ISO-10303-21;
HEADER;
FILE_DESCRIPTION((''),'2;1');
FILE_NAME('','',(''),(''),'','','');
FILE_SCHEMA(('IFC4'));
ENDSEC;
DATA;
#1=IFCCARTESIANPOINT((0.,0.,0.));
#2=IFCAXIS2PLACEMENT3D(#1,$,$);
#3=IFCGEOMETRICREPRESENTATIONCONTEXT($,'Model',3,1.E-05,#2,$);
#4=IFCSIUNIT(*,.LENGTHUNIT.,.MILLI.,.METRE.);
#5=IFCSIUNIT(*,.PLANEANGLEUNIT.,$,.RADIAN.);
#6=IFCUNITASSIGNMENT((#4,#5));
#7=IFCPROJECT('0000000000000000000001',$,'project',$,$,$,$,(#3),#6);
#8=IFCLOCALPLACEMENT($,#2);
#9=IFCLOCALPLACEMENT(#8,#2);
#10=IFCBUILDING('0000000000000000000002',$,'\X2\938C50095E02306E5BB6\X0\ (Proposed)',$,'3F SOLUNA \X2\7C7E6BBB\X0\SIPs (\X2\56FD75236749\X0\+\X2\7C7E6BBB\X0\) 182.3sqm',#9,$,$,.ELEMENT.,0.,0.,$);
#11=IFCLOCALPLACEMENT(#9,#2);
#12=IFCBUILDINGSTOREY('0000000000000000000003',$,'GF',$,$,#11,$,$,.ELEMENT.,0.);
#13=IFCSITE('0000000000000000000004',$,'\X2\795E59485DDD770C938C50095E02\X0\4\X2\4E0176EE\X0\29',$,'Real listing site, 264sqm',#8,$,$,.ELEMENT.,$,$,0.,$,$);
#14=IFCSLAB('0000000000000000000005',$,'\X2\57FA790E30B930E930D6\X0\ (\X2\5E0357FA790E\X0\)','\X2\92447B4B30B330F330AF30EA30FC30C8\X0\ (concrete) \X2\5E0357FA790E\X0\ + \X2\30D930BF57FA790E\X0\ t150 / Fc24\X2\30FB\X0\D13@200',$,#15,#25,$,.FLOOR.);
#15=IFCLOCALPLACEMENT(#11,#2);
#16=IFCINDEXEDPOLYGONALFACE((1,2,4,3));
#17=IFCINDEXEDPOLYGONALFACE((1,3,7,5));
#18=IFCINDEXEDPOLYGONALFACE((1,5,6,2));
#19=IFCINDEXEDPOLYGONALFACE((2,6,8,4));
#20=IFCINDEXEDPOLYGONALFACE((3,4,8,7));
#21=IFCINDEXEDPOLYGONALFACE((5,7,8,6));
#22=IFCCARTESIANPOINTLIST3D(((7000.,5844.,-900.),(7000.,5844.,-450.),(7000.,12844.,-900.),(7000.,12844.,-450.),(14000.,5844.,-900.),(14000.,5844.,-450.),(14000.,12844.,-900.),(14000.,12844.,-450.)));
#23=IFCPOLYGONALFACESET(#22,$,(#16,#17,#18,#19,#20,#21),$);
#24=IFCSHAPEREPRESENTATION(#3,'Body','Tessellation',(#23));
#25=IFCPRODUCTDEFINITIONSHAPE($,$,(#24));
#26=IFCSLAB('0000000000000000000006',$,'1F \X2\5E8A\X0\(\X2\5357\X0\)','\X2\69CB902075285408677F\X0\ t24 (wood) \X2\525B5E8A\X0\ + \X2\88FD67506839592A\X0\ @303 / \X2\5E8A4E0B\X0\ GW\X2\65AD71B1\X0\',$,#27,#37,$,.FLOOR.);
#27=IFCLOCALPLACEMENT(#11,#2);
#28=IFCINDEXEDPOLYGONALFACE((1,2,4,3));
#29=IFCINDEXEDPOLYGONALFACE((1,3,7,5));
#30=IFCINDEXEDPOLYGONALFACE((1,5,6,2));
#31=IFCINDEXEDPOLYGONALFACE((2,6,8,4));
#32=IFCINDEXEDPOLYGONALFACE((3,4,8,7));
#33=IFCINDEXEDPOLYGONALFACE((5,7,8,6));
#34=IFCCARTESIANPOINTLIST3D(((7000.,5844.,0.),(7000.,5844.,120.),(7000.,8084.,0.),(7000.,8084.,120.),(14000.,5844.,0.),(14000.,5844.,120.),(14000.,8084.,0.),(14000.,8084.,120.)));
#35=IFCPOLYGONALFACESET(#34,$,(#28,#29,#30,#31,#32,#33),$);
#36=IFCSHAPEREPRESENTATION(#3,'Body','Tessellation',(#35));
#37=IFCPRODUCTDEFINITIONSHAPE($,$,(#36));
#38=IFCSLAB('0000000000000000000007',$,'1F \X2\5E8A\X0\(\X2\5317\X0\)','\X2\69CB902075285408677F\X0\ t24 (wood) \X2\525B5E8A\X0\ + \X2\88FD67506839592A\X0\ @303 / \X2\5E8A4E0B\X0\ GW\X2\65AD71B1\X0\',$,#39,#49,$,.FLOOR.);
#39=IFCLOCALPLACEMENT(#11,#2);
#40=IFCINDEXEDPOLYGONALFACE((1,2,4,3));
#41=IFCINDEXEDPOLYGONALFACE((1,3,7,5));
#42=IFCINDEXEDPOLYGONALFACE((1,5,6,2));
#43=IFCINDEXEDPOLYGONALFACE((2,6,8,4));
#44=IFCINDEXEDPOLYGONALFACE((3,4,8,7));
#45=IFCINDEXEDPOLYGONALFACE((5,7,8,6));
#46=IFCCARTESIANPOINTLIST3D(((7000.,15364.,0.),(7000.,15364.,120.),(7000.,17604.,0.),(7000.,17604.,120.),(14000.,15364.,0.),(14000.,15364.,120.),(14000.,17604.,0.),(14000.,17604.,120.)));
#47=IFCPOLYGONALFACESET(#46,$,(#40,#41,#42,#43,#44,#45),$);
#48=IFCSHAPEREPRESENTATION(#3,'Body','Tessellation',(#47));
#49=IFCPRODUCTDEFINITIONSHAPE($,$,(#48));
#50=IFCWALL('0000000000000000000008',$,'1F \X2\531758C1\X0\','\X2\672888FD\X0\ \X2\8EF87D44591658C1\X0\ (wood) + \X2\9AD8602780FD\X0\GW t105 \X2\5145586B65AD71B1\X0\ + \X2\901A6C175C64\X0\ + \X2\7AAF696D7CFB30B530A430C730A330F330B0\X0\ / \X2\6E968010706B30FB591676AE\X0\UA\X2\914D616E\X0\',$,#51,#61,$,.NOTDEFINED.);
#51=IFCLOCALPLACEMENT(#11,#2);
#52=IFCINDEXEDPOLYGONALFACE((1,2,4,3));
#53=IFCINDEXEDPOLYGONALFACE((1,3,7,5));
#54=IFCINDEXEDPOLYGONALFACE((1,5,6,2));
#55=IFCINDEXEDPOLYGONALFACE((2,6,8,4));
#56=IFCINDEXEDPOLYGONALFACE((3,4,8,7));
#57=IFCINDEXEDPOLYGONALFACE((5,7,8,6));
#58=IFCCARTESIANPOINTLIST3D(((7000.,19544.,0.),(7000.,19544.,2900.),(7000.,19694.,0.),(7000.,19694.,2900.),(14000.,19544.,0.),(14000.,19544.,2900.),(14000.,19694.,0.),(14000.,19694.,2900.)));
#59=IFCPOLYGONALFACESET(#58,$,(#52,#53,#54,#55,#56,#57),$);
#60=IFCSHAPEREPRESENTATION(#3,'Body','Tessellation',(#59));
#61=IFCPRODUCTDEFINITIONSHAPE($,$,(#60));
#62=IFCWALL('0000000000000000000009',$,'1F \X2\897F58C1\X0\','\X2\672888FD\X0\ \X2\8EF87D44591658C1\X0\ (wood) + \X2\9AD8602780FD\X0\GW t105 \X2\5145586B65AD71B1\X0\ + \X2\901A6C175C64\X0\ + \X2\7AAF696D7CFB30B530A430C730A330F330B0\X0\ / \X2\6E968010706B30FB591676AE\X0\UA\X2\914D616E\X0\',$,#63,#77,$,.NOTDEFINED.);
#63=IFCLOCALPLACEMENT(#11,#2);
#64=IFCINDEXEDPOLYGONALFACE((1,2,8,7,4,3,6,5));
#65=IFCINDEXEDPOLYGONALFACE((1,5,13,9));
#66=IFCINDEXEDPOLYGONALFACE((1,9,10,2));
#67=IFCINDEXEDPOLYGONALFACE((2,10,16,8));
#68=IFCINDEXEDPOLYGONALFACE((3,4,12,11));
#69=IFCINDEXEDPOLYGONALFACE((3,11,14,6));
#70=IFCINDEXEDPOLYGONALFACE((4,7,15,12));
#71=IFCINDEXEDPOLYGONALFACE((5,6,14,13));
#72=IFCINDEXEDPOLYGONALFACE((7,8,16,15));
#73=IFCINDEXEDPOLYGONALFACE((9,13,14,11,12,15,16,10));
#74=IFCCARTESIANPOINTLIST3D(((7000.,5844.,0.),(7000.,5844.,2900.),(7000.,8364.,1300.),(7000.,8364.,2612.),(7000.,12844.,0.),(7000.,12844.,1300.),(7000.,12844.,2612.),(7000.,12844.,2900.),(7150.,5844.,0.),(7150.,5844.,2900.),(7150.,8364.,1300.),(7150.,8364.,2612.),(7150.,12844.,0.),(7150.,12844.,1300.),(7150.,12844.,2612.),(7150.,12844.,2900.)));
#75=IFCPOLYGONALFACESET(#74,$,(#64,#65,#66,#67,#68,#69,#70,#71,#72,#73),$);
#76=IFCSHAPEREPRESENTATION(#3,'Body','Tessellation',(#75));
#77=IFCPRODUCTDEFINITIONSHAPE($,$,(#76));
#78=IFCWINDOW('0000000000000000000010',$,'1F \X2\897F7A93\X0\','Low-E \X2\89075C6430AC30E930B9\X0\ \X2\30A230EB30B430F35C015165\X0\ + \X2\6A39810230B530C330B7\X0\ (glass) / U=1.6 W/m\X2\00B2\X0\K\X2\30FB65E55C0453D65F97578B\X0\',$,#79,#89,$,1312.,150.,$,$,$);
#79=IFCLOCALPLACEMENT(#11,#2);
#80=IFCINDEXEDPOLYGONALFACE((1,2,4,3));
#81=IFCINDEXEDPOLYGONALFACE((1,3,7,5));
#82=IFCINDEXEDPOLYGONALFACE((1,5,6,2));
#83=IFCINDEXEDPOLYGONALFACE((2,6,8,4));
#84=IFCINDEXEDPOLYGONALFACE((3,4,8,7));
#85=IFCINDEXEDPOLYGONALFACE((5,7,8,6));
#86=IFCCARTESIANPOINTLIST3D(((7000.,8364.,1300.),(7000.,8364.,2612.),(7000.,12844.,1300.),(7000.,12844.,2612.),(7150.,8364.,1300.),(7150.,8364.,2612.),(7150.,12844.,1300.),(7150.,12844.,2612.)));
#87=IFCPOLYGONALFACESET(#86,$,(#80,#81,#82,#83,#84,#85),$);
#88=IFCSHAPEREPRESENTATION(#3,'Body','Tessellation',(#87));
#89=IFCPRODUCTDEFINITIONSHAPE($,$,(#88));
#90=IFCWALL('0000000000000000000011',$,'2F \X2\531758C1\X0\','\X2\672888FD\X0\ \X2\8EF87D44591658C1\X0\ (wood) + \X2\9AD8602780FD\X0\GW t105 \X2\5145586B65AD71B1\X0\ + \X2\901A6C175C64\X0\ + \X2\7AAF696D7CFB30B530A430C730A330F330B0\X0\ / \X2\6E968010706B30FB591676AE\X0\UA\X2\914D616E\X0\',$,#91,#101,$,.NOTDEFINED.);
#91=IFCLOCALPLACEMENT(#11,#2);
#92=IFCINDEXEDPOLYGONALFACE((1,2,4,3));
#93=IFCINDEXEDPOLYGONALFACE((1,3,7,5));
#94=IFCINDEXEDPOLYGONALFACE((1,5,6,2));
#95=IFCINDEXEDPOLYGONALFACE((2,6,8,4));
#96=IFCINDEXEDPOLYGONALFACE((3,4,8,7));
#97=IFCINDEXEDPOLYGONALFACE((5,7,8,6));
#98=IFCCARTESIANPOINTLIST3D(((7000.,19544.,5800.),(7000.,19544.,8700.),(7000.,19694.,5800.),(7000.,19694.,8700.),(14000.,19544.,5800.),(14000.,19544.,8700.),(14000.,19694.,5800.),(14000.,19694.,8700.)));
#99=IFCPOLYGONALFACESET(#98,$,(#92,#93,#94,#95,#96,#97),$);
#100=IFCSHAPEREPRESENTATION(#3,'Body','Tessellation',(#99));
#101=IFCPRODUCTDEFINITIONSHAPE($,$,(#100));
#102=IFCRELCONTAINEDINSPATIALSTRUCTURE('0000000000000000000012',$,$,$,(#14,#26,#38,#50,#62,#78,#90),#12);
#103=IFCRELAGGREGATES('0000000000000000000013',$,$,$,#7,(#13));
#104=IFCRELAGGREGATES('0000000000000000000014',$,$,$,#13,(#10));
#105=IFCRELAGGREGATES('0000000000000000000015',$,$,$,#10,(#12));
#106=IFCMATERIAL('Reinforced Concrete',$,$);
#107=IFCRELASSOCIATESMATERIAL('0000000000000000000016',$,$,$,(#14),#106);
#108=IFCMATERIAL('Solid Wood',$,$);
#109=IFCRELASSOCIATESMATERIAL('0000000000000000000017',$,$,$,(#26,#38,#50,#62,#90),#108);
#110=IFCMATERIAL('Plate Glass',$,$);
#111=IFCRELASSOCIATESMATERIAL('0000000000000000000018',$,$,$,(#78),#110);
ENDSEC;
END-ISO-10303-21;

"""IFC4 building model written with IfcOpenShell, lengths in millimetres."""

from ifc_helpers import new_model, si_unit, frame, frame_2d, origin, place, context, project, spatial, rectangle, extrude, material, element, fill, save


model = new_model("IFC4")

# Units and contexts
model_context = context("Model", 3, precision=1e-05, world=origin())
ifc_project = project(units=[si_unit("LENGTHUNIT", "METRE", prefix="MILLI"), si_unit("PLANEANGLEUNIT", "RADIAN")], contexts=[model_context])

# Site, building, storey
site_placement = place(None, origin())
site = spatial("IfcSite", under=ifc_project, at=site_placement, Name="神奈川県鎌倉市4丁目29", ObjectType="Real listing site, 264sqm", CompositionType="ELEMENT", RefElevation=0.0)
building_placement = place(site_placement, origin())
building = spatial("IfcBuilding", under=site, at=building_placement, Name="鎌倉市の家 (Proposed)", ObjectType="3F SOLUNA 籾殻SIPs (国産杉+籾殻) 182.3sqm", CompositionType="ELEMENT", ElevationOfRefHeight=0.0, ElevationOfTerrain=0.0)
storey_placement = place(building_placement, origin())
storey = spatial("IfcBuildingStorey", under=building, at=storey_placement, Name="GF", CompositionType="ELEMENT", Elevation=0.0)

# Slabs
ifc_material_1 = material(Name="Reinforced Concrete")
slab_1_placement = place(storey_placement, frame((3500.0, 2922.0, -450.0)))
element("IfcSlab", 1, at=slab_1_placement, inside=storey, material=ifc_material_1, Name="基礎スラブ (布基礎)", Description="鉄筋コンクリート (concrete) 布基礎 + ベタ基礎 t150 / Fc24・D13@200", PredefinedType="FLOOR", context=model_context, shape_type="SweptSolid", body=[
    extrude(rectangle(XDim=7000.0, YDim=7000.0, at=frame_2d((3500.0, 3500.0))), frame((3500.0, 2922.0, -450.0)), (0.0, 0.0, 1.0), 450.0),
])
ifc_material_2 = material(Name="Solid Wood")
slab_2_placement = place(storey_placement, frame((3500.0, 2922.0, 0.0)))
element("IfcSlab", 2, at=slab_2_placement, inside=storey, material=ifc_material_2, Name="1F 床(南)", Description="構造用合板 t24 (wood) 剛床 + 製材根太 @303 / 床下 GW断熱", PredefinedType="FLOOR", context=model_context, shape_type="SweptSolid", body=[
    extrude(rectangle(XDim=7000.0, YDim=2240.0, at=frame_2d((3500.0, 1120.0))), frame((3500.0, 2922.0, 0.0)), (0.0, 0.0, 1.0), 120.0),
])
slab_3_placement = place(storey_placement, frame((3500.0, 7682.0, 0.0)))
element("IfcSlab", 3, at=slab_3_placement, inside=storey, material=ifc_material_2, Name="1F 床(北)", Description="構造用合板 t24 (wood) 剛床 + 製材根太 @303 / 床下 GW断熱", PredefinedType="FLOOR", context=model_context, shape_type="SweptSolid", body=[
    extrude(rectangle(XDim=7000.0, YDim=2240.0, at=frame_2d((3500.0, 1120.0))), frame((3500.0, 7682.0, 0.0)), (0.0, 0.0, 1.0), 120.0),
])

# Shared definitions
ifc_material_3 = material(Name="Plate Glass")

# Wall
wall_1_placement = place(storey_placement, frame((3500.0, 9772.0, 0.0)))
element("IfcWall", 4, at=wall_1_placement, inside=storey, material=ifc_material_2, Name="1F 北壁", Description="木製 軸組外壁 (wood) + 高性能GW t105 充填断熱 + 通気層 + 窯業系サイディング / 準耐火・外皮UA配慮", PredefinedType="NOTDEFINED", context=model_context, shape_type="SweptSolid", body=[
    extrude(rectangle(XDim=7000.0, YDim=150.0, at=frame_2d((3500.0, 75.0))), frame((3500.0, 9772.0, 0.0)), (0.0, 0.0, 1.0), 2900.0),
])

# Wall, opening, window
wall_2_placement = place(storey_placement, frame((3500.0, 2922.0, 0.0)))
wall_2 = element("IfcWall", 5, at=wall_2_placement, inside=storey, material=ifc_material_2, Name="1F 西壁", Description="木製 軸組外壁 (wood) + 高性能GW t105 充填断熱 + 通気層 + 窯業系サイディング / 準耐火・外皮UA配慮", PredefinedType="NOTDEFINED", context=model_context, shape_type="SweptSolid", body=[
    extrude(rectangle(XDim=150.0, YDim=7000.0, at=frame_2d((75.0, 3500.0))), frame((3500.0, 2922.0, 0.0)), (0.0, 0.0, 1.0), 2900.0),
])
opening_1_placement = place(storey_placement, frame((3500.0, 4182.0, 650.0)))
opening_1 = element("IfcOpeningElement", 6, at=opening_1_placement, cuts=wall_2, PredefinedType="NOTDEFINED", context=model_context, shape_type="SweptSolid", body=[
    extrude(rectangle(XDim=150.0, YDim=4480.0, at=frame_2d((75.0, 2240.0))), frame((3500.0, 4182.0, 650.0)), (0.0, 0.0, 1.0), 1312.0),
])
window_1_placement = place(storey_placement, frame((3500.0, 4182.0, 650.0)))
window_1 = element("IfcWindow", 7, at=window_1_placement, inside=storey, material=ifc_material_3, Name="1F 西窓", Description="Low-E 複層ガラス アルゴン封入 + 樹脂サッシ (glass) / U=1.6 W/m²K・日射取得型", OverallHeight=1312.0, OverallWidth=150.0, context=model_context, shape_type="SweptSolid", body=[
    extrude(rectangle(XDim=150.0, YDim=4480.0, at=frame_2d((75.0, 2240.0))), frame((3500.0, 4182.0, 650.0)), (0.0, 0.0, 1.0), 1312.0),
])
fill(opening_1, window_1)

# Wall
wall_3_placement = place(storey_placement, frame((3500.0, 9772.0, 2900.0)))
element("IfcWall", 8, at=wall_3_placement, inside=storey, material=ifc_material_2, Name="2F 北壁", Description="木製 軸組外壁 (wood) + 高性能GW t105 充填断熱 + 通気層 + 窯業系サイディング / 準耐火・外皮UA配慮", PredefinedType="NOTDEFINED", context=model_context, shape_type="SweptSolid", body=[
    extrude(rectangle(XDim=7000.0, YDim=150.0, at=frame_2d((3500.0, 75.0))), frame((3500.0, 9772.0, 2900.0)), (0.0, 0.0, 1.0), 2900.0),
])

save(model, "model.ifc")
